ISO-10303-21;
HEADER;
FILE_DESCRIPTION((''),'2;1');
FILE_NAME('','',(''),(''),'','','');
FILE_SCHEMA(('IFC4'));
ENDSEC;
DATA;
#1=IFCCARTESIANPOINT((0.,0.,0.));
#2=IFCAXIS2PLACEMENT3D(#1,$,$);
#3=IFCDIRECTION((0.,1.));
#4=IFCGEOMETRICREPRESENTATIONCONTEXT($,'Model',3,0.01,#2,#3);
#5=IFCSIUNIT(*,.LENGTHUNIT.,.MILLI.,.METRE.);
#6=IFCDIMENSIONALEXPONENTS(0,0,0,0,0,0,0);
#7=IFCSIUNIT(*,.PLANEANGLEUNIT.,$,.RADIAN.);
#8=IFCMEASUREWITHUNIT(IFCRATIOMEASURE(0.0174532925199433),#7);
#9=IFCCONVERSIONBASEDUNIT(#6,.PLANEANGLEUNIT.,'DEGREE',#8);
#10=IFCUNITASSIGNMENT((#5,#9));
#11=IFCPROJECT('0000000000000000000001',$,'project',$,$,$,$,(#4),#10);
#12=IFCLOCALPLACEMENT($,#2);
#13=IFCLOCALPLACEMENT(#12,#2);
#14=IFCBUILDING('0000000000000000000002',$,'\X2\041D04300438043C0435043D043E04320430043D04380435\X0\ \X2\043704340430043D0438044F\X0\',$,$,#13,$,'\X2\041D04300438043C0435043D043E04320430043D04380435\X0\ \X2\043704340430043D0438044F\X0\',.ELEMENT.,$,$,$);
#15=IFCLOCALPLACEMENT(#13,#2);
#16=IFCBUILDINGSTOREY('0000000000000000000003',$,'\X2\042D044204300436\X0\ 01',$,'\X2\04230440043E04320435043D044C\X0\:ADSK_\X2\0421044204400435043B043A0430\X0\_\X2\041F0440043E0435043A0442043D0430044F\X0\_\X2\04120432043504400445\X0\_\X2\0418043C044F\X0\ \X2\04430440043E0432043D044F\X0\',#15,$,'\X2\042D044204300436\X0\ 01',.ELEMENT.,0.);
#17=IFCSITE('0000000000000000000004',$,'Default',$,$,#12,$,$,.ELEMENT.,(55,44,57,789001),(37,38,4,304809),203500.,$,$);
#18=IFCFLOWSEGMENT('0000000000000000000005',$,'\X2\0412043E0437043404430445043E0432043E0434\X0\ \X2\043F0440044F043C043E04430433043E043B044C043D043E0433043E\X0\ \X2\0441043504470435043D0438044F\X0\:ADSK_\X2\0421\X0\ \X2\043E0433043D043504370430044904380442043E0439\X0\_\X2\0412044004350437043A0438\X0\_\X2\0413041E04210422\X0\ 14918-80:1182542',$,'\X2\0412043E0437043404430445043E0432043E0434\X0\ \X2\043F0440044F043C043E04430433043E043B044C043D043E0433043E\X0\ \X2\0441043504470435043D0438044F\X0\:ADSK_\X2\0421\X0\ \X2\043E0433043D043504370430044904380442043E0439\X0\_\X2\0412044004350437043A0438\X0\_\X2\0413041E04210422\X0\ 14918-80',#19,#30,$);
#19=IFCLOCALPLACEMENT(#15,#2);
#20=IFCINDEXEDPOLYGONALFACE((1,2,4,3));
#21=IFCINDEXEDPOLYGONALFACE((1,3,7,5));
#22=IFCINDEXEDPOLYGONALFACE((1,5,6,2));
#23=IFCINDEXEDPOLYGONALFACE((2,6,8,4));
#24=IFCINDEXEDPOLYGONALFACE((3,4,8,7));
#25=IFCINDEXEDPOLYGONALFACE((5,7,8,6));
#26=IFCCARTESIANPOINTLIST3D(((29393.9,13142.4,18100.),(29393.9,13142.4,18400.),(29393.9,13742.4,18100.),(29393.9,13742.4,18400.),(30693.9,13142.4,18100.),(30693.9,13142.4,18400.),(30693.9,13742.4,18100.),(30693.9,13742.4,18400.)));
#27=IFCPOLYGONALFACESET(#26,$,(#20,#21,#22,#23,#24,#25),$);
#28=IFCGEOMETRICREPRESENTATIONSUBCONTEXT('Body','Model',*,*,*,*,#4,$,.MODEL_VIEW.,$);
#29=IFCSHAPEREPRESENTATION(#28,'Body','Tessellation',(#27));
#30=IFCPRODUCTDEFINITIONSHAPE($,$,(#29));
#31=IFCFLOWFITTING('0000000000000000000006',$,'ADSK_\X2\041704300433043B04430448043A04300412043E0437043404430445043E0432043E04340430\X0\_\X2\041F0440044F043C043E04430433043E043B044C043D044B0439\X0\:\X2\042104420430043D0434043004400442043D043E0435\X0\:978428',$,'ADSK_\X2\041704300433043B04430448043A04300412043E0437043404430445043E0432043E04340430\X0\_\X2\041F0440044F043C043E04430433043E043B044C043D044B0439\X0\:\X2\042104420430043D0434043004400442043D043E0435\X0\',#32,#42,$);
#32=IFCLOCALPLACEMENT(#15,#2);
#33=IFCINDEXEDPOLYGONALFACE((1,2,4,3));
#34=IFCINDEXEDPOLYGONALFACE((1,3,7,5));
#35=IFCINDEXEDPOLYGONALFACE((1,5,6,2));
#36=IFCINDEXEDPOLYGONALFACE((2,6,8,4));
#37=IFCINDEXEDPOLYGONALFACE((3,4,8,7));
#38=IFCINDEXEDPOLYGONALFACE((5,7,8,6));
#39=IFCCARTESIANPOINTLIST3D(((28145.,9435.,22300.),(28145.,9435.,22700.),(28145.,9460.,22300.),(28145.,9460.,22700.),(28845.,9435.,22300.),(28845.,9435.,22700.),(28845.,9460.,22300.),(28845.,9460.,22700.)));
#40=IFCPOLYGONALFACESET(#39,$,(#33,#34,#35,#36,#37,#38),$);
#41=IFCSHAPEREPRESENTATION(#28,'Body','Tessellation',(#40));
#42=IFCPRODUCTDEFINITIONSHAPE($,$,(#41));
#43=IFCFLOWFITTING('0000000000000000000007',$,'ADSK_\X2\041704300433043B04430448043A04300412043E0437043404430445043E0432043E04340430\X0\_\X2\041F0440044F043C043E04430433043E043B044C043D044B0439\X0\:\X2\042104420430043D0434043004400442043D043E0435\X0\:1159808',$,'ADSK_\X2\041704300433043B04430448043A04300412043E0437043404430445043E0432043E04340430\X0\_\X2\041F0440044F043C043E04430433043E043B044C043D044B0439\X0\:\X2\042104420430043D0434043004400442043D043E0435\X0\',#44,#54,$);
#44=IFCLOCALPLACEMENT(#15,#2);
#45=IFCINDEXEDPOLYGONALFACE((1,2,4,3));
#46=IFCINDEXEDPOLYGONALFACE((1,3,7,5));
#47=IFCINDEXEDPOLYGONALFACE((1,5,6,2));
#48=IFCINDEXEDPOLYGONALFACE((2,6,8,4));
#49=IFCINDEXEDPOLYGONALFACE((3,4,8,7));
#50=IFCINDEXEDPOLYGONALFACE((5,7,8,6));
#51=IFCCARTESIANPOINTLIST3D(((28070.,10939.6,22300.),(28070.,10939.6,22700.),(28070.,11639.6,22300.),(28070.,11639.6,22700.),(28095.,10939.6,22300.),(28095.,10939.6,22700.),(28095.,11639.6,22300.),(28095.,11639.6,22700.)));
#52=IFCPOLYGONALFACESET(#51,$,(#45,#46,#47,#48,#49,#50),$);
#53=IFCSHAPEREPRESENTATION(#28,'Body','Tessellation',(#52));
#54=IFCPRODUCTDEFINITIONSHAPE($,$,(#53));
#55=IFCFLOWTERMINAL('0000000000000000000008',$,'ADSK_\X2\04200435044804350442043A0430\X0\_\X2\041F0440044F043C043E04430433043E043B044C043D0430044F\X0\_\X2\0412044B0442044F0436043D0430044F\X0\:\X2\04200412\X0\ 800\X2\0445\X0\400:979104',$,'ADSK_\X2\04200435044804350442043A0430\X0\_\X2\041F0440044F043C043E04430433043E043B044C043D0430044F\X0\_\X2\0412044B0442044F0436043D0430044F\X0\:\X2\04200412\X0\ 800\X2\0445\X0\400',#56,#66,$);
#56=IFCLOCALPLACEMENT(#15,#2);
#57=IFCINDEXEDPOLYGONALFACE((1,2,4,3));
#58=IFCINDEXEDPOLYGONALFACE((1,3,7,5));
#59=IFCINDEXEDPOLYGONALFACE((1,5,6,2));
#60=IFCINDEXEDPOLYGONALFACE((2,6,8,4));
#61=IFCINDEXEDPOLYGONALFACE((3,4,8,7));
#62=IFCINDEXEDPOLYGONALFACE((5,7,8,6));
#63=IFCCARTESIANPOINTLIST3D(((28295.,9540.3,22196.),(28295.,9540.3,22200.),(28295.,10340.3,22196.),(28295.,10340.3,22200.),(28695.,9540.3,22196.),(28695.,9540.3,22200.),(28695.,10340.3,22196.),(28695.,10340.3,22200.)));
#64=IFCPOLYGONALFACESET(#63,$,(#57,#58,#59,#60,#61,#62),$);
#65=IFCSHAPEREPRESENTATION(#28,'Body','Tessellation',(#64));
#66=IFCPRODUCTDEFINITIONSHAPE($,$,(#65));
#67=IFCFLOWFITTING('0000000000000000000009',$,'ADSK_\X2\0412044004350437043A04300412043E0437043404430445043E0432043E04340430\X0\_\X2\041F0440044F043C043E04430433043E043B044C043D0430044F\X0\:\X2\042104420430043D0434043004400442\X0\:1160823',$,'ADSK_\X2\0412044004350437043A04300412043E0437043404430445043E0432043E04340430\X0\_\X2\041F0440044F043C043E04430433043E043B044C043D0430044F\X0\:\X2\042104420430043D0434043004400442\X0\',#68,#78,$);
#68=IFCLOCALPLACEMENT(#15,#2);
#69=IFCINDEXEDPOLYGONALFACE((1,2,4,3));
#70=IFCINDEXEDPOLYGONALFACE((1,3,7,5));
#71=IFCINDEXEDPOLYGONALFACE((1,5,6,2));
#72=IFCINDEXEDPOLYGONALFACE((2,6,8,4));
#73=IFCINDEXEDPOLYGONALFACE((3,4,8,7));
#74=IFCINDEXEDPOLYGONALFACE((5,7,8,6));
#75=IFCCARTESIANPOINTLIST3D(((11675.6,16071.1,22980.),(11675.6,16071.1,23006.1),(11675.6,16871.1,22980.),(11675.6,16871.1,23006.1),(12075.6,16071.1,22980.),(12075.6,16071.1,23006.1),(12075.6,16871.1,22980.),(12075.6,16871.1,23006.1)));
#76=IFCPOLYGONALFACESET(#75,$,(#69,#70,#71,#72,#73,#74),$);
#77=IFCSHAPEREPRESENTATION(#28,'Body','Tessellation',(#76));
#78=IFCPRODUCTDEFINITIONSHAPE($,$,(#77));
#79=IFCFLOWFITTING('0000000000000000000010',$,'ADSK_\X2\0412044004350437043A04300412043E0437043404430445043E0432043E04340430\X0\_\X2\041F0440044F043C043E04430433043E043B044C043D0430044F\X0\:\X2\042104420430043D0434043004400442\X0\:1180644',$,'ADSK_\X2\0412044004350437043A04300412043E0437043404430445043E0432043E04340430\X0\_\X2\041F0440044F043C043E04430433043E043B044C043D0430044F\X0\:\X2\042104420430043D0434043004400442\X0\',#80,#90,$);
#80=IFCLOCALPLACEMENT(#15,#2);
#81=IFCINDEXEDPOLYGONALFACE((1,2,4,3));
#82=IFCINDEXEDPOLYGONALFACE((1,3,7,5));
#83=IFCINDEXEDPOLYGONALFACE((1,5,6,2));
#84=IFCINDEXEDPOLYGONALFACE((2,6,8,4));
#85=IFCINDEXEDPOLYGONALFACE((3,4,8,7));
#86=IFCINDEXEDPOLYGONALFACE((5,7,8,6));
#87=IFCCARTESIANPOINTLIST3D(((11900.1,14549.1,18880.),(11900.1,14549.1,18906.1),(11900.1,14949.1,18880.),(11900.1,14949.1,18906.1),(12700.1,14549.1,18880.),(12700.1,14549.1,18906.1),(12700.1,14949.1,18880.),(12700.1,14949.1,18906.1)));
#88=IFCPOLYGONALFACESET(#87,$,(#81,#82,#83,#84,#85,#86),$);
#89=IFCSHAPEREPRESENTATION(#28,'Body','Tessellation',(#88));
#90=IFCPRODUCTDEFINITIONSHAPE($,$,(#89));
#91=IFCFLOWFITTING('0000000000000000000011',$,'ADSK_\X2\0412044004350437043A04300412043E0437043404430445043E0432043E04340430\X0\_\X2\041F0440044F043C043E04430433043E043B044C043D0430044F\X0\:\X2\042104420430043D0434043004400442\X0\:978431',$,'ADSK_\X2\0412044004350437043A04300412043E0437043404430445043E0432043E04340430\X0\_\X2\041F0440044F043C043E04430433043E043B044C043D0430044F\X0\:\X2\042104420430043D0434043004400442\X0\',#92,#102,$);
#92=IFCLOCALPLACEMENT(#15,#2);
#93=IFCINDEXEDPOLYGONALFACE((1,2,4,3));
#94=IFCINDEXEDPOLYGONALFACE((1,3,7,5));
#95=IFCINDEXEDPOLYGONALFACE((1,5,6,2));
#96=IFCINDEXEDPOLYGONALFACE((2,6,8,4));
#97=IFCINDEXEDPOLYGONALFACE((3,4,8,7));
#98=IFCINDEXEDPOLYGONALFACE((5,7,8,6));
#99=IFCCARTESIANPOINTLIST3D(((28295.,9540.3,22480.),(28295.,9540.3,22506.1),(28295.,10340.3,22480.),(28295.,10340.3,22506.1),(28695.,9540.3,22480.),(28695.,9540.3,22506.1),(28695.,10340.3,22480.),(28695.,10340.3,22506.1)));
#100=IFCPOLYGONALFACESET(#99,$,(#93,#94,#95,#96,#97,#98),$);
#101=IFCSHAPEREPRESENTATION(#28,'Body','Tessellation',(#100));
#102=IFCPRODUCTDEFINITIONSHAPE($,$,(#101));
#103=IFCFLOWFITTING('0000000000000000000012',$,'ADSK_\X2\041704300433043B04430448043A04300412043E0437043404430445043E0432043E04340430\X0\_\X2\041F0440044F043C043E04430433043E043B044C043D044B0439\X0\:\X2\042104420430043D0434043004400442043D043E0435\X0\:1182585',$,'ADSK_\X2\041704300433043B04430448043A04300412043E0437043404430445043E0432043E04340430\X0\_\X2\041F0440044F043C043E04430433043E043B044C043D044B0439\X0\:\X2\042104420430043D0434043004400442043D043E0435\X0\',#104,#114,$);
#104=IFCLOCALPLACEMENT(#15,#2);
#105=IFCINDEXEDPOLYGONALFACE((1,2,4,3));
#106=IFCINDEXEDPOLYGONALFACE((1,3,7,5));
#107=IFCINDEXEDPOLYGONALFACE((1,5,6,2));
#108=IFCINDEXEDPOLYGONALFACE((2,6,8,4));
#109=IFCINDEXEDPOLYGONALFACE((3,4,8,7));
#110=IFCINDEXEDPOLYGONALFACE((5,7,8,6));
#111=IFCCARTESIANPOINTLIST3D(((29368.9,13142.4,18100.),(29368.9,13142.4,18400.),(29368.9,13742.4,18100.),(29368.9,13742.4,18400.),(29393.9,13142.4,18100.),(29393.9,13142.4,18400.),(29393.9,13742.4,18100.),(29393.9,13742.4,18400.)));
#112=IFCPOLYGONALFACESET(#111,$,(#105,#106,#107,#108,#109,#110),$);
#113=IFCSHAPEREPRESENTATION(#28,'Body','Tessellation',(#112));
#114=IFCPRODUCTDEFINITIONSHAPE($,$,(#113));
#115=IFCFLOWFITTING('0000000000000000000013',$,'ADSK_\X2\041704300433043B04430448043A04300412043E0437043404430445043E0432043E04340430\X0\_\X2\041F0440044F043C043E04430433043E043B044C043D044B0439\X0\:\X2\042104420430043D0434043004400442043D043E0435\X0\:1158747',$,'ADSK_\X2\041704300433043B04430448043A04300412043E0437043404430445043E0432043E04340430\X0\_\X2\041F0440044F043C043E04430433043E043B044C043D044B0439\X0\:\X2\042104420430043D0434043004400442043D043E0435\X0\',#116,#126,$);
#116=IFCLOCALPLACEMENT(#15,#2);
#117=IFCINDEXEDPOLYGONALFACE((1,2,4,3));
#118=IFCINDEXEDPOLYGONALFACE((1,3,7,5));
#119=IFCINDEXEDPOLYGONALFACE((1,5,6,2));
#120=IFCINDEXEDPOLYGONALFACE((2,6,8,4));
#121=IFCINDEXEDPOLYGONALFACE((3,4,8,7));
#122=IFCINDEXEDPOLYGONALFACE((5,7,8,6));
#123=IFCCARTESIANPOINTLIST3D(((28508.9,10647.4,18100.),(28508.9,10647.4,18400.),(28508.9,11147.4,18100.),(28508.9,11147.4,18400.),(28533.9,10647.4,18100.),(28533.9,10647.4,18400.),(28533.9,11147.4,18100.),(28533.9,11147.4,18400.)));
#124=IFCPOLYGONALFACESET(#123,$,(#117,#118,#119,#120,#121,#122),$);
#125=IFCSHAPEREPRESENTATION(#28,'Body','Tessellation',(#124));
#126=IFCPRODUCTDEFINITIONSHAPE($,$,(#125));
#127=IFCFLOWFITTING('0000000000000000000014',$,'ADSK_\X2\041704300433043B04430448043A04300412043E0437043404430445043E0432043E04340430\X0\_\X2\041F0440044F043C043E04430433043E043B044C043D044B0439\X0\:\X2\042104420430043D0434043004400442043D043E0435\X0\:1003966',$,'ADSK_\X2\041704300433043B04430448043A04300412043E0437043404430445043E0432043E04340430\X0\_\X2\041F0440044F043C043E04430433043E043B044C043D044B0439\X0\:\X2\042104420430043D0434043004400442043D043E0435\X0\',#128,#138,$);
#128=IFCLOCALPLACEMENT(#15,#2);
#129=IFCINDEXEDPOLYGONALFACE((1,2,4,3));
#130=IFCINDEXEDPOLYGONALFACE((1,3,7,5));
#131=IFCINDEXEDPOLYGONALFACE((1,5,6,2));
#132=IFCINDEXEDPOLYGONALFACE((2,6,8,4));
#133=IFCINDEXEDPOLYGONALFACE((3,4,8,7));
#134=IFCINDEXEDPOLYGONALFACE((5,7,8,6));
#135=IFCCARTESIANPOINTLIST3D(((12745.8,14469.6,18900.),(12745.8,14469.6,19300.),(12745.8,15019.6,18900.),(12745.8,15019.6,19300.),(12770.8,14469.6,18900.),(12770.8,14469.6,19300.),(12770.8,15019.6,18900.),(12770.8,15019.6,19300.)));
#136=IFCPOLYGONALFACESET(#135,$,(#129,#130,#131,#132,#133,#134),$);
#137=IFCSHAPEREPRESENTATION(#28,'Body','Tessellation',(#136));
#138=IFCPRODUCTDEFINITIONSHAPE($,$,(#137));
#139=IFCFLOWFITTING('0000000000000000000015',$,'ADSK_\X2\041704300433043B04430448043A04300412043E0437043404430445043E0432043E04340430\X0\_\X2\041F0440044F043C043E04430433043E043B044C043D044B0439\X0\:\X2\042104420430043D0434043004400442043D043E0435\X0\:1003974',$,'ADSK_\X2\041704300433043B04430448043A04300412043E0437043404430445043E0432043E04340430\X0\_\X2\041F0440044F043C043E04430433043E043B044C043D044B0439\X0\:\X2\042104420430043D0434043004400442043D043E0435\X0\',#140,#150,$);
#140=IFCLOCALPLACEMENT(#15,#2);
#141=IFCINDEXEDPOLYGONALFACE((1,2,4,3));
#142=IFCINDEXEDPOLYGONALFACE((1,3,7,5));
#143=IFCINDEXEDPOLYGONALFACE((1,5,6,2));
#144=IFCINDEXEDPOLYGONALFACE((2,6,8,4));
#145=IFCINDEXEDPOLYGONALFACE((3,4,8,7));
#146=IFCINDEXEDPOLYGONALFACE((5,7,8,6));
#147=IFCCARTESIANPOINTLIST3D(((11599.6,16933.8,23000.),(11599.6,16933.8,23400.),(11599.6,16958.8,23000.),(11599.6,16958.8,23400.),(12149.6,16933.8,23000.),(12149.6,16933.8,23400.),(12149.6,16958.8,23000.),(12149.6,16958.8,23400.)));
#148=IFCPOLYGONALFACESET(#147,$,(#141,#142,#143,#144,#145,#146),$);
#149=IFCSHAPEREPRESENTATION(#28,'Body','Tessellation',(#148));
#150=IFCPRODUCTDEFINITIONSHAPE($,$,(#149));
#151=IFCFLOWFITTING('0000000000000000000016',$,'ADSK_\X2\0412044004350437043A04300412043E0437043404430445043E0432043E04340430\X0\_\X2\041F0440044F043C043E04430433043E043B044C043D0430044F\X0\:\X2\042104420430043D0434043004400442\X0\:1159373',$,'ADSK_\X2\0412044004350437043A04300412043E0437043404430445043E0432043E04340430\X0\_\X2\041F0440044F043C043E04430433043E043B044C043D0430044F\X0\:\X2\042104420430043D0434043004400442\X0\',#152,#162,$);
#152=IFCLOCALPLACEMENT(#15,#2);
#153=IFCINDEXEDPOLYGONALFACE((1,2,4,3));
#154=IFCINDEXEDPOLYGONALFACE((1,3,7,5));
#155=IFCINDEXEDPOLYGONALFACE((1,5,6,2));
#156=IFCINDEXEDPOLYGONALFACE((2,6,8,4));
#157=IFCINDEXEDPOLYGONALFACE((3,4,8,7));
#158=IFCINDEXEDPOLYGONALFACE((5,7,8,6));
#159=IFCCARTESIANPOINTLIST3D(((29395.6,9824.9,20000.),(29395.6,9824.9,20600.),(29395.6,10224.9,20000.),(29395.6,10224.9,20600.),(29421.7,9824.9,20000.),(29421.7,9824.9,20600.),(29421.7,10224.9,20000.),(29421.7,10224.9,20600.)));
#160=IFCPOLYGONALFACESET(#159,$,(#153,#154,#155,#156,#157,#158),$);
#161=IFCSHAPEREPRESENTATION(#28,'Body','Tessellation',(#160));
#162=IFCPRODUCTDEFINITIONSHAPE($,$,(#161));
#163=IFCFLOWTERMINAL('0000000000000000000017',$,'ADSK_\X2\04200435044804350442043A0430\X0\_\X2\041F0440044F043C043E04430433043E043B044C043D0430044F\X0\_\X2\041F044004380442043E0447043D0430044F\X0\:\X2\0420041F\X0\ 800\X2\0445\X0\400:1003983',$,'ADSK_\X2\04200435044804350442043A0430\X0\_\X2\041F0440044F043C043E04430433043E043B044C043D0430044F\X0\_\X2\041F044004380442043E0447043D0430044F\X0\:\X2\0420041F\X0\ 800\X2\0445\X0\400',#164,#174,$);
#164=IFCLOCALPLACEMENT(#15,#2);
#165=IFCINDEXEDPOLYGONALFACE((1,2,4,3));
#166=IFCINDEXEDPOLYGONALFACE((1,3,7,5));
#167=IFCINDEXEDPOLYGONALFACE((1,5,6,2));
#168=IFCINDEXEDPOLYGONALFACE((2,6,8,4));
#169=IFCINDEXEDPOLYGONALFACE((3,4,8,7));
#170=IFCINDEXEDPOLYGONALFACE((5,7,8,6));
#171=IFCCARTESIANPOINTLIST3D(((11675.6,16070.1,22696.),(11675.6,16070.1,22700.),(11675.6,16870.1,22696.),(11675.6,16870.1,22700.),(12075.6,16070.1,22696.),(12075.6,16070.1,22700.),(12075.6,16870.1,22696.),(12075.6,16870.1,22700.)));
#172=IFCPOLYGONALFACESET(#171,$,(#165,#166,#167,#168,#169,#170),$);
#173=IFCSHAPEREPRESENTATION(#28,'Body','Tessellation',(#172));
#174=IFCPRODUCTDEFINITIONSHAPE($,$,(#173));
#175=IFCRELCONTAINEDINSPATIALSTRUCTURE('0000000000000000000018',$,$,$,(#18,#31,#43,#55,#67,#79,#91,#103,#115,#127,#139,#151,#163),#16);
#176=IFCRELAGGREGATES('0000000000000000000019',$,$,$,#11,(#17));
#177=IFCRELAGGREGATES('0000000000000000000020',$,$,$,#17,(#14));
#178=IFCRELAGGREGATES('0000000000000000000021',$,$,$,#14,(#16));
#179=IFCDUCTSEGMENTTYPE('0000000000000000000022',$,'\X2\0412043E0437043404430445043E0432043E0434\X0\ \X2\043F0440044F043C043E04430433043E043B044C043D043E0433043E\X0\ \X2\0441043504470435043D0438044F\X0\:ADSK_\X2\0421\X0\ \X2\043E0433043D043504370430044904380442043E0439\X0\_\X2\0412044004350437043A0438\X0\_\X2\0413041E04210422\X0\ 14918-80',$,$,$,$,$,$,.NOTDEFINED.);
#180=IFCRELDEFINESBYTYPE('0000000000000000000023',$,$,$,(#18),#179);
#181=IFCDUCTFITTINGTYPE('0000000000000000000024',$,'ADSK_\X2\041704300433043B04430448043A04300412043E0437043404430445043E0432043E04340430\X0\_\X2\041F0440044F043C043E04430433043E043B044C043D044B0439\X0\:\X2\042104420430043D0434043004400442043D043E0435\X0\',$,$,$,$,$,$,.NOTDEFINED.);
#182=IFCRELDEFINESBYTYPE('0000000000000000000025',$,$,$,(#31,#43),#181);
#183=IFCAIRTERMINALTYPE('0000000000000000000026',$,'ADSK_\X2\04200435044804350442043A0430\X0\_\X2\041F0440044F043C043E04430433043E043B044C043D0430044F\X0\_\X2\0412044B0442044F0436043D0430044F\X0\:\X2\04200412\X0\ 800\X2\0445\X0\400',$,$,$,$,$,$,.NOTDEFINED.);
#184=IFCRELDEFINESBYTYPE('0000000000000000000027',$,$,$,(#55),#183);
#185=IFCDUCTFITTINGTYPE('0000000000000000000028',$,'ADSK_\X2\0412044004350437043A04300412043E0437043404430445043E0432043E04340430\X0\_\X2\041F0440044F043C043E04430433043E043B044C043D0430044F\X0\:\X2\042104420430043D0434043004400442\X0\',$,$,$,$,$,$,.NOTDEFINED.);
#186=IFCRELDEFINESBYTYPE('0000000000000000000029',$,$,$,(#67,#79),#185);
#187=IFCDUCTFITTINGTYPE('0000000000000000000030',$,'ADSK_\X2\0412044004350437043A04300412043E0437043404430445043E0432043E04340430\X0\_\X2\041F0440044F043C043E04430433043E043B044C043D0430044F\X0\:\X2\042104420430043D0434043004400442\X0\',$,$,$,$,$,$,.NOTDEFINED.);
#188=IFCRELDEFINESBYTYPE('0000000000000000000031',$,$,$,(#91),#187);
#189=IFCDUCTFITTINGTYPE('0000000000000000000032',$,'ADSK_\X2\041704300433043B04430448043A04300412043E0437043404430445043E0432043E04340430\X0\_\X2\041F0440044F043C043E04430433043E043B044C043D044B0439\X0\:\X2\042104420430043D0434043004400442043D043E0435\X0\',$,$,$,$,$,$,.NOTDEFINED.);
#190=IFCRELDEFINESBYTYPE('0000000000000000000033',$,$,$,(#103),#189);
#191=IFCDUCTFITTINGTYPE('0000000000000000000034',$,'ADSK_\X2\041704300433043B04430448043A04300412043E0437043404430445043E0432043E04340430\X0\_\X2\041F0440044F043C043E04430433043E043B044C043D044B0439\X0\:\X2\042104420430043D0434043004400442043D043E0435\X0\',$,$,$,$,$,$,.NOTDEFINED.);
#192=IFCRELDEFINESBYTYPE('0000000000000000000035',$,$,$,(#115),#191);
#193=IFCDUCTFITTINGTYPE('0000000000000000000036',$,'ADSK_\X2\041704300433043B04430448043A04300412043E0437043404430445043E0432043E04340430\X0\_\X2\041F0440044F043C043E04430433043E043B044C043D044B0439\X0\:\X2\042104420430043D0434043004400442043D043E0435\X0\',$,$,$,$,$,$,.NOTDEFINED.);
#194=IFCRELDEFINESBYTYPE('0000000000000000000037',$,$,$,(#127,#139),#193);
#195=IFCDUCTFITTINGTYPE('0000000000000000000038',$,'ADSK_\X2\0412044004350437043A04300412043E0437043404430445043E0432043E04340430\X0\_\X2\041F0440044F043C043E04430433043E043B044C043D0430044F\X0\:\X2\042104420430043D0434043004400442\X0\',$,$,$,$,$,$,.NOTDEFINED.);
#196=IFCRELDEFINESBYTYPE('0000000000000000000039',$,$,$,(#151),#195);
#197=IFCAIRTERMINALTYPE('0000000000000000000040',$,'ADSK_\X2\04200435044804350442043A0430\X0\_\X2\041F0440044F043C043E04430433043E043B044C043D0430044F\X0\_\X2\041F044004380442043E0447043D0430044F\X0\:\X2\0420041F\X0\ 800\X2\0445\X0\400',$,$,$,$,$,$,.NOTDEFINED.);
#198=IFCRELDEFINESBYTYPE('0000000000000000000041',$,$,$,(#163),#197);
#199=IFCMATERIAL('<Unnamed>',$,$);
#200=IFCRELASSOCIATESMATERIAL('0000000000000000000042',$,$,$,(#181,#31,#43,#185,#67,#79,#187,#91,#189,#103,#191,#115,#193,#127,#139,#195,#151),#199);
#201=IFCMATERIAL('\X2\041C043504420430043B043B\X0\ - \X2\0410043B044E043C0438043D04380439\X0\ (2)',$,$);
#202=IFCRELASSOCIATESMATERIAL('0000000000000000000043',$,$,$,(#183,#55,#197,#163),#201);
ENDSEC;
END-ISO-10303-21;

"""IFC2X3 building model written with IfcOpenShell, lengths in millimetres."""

from ifc_helpers import new_model, entity, si_unit, converted_unit, direction, frame, frame_2d, origin, origin_2d_with_axis, place, context, subcontext, project, spatial, rectangle, extrude, source, transform, mapped, material, type_object, type_shapes, element, save


model = new_model("IFC2X3")

# Units and contexts
model_context = context("Model", 3, precision=0.01, world=origin(), true_north=direction((0.0, 1.0)))
body_context = subcontext(model_context, "Body", "Model", "MODEL_VIEW")
ifc_project = project(units=[si_unit("LENGTHUNIT", "METRE", prefix="MILLI"), converted_unit("PLANEANGLEUNIT", "DEGREE", entity("IfcRatioMeasure", 0.0174532925199433), si_unit("PLANEANGLEUNIT", "RADIAN"), dimensions=[0, 0, 0, 0, 0, 0, 0])], contexts=[model_context])

# Site, building, storey
site_placement = place(None, frame((0.0, 0.0, 0.0)))
site = spatial("IfcSite", under=ifc_project, at=site_placement, Name="Default", CompositionType="ELEMENT", RefLatitude=(55, 44, 57, 789001), RefLongitude=(37, 38, 4, 304809), RefElevation=203500.0)
building_placement = place(site_placement, origin())
building = spatial("IfcBuilding", under=site, at=building_placement, Name="Наименование здания", LongName="Наименование здания", CompositionType="ELEMENT")
storey_placement = place(building_placement, origin())
storey = spatial("IfcBuildingStorey", under=building, at=storey_placement, Name="Этаж 01", ObjectType="Уровень:ADSK_Стрелка_Проектная_Вверх_Имя уровня", LongName="Этаж 01", CompositionType="ELEMENT", Elevation=0.0)

# Flow segment
duct_segment_type = type_object("IfcDuctSegmentType", Name="Воздуховод прямоугольного сечения:ADSK_С огнезащитой_Врезки_ГОСТ 14918-80", PredefinedType="NOTDEFINED")
flow_segment_1_placement = place(storey_placement, frame((29393.9, 13142.4, 18100.0)))
element("IfcFlowSegment", 1, at=flow_segment_1_placement, inside=storey, type_object=duct_segment_type, Name="Воздуховод прямоугольного сечения:ADSK_С огнезащитой_Врезки_ГОСТ 14918-80:1182542", ObjectType="Воздуховод прямоугольного сечения:ADSK_С огнезащитой_Врезки_ГОСТ 14918-80", context=body_context, shape_type="SweptSolid", body=[
    extrude(rectangle(XDim=1300.0, YDim=600.0, at=frame_2d((0.0, 0.0), x_axis=(1.0, 0.0))), frame((650.0, 300.0, 0.0), z_axis=(0.0, 0.0, 1.0), x_axis=(-1.0, 0.0, 0.0)), (0.0, 0.0, 1.0), 300.0),
])

# Flow fittings
ifc_material_1 = material(Name="<Unnamed>")
duct_fitting_type_1 = type_object("IfcDuctFittingType", Name="ADSK_ЗаглушкаВоздуховода_Прямоугольный:Стандартное", PredefinedType="NOTDEFINED", material=ifc_material_1)
shared_shape_1 = source(origin(), body_context, "Body", "SweptSolid", [
    extrude(rectangle(XDim=25.0, YDim=700.0, at=frame_2d((0.0, 0.0), x_axis=(1.0, 0.0))), frame((12.5, 0.0, -200.0)), (0.0, 0.0, 1.0), 400.0),
])
type_shapes(duct_fitting_type_1, [shared_shape_1])
for number, where, z_axis, x_axis, name in (
    (2, (28495.0, 9460.0, 22500.0), (0.0, 0.0, 1.0), (0.0, -1.0, 0.0), "ADSK_ЗаглушкаВоздуховода_Прямоугольный:Стандартное:978428"),
    (3, (28095.0, 11289.6, 22500.0), (0.0, 0.0, 1.0), (-1.0, 0.0, 0.0), "ADSK_ЗаглушкаВоздуховода_Прямоугольный:Стандартное:1159808"),
):
    element("IfcFlowFitting", number, at=place(storey_placement, frame(where, z_axis=z_axis, x_axis=x_axis)), inside=storey, type_object=duct_fitting_type_1, material=ifc_material_1, Name=name, ObjectType="ADSK_ЗаглушкаВоздуховода_Прямоугольный:Стандартное", context=body_context, shape_type="MappedRepresentation", body=[
        mapped(shared_shape_1, transform((0.0, 0.0, 0.0), scale=1.0)),
    ])

# Flow terminal
ifc_material_2 = material(Name="Металл - Алюминий (2)")
air_terminal_type_1 = type_object("IfcAirTerminalType", Name="ADSK_Решетка_Прямоугольная_Вытяжная:РВ 800х400", PredefinedType="NOTDEFINED", material=ifc_material_2)
shared_shape_2 = source(origin(), body_context, "Body", "SweptSolid", [
    extrude(rectangle(XDim=4.0, YDim=800.0, at=origin_2d_with_axis()), frame((0.0, -2.0, -200.0), z_axis=(0.0, 0.0, 1.0), x_axis=(0.0, 1.0, 0.0)), (0.0, 0.0, 1.0), 400.0),
])
type_shapes(air_terminal_type_1, [shared_shape_2])
flow_terminal_1_placement = place(storey_placement, frame((28495.0, 9940.3, 22200.0), z_axis=(-1.0, 0.0, 0.0), x_axis=(0.0, -1.0, 0.0)))
element("IfcFlowTerminal", 4, at=flow_terminal_1_placement, inside=storey, type_object=air_terminal_type_1, material=ifc_material_2, Name="ADSK_Решетка_Прямоугольная_Вытяжная:РВ 800х400:979104", ObjectType="ADSK_Решетка_Прямоугольная_Вытяжная:РВ 800х400", context=body_context, shape_type="MappedRepresentation", body=[
    mapped(shared_shape_2, transform((0.0, 0.0, 0.0), scale=1.0)),
])

# Flow fittings
duct_fitting_type_2 = type_object("IfcDuctFittingType", Name="ADSK_ВрезкаВоздуховода_Прямоугольная:Стандарт", PredefinedType="NOTDEFINED", material=ifc_material_1)
shared_shape_3 = source(origin(), body_context, "Body", "SweptSolid", [
    extrude(rectangle(XDim=26.1, YDim=800.0, at=frame_2d((0.0, 0.0), x_axis=(1.0, 0.0))), frame((7.0, 0.0, -200.0)), (0.0, 0.0, 1.0), 400.0),
])
type_shapes(duct_fitting_type_2, [shared_shape_3])
for number, where, z_axis, x_axis, name in (
    (5, (11875.6, 16471.1, 23000.0), (1.0, 0.0, 0.0), (0.0, 0.0, -1.0), "ADSK_ВрезкаВоздуховода_Прямоугольная:Стандарт:1160823"),
    (6, (12300.1, 14749.1, 18900.0), (0.0, 1.0, 0.0), (0.0, 0.0, -1.0), "ADSK_ВрезкаВоздуховода_Прямоугольная:Стандарт:1180644"),
):
    element("IfcFlowFitting", number, at=place(storey_placement, frame(where, z_axis=z_axis, x_axis=x_axis)), inside=storey, type_object=duct_fitting_type_2, material=ifc_material_1, Name=name, ObjectType="ADSK_ВрезкаВоздуховода_Прямоугольная:Стандарт", context=body_context, shape_type="MappedRepresentation", body=[
        mapped(shared_shape_3, transform((0.0, 0.0, 0.0), scale=1.0)),
    ])
duct_fitting_type_3 = type_object("IfcDuctFittingType", Name="ADSK_ВрезкаВоздуховода_Прямоугольная:Стандарт", PredefinedType="NOTDEFINED", material=ifc_material_1)
shared_shape_4 = source(origin(), body_context, "Body", "SweptSolid", [
    extrude(rectangle(XDim=800.0, YDim=26.1, at=frame_2d((0.0, 0.0), x_axis=(1.0, 0.0))), frame((7.0, 0.0, -200.0), z_axis=(0.0, 0.0, 1.0), x_axis=(0.0, -1.0, 0.0)), (0.0, 0.0, 1.0), 400.0),
])
type_shapes(duct_fitting_type_3, [shared_shape_4])
flow_fitting_1_placement = place(storey_placement, frame((28495.0, 9940.3, 22500.0), z_axis=(-1.0, 0.0, 0.0), x_axis=(0.0, 0.0, -1.0)))
element("IfcFlowFitting", 7, at=flow_fitting_1_placement, inside=storey, type_object=duct_fitting_type_3, material=ifc_material_1, Name="ADSK_ВрезкаВоздуховода_Прямоугольная:Стандарт:978431", ObjectType="ADSK_ВрезкаВоздуховода_Прямоугольная:Стандарт", context=body_context, shape_type="MappedRepresentation", body=[
    mapped(shared_shape_4, transform((0.0, 0.0, 0.0), scale=1.0)),
])
duct_fitting_type_4 = type_object("IfcDuctFittingType", Name="ADSK_ЗаглушкаВоздуховода_Прямоугольный:Стандартное", PredefinedType="NOTDEFINED", material=ifc_material_1)
shared_shape_5 = source(origin(), body_context, "Body", "SweptSolid", [
    extrude(rectangle(XDim=25.0, YDim=600.0, at=frame_2d((0.0, 0.0), x_axis=(1.0, 0.0))), frame((12.5, 0.0, -150.0)), (0.0, 0.0, 1.0), 300.0),
])
type_shapes(duct_fitting_type_4, [shared_shape_5])
flow_fitting_2_placement = place(storey_placement, frame((29393.9, 13442.4, 18250.0), z_axis=(0.0, 0.0, 1.0), x_axis=(-1.0, 0.0, 0.0)))
element("IfcFlowFitting", 8, at=flow_fitting_2_placement, inside=storey, type_object=duct_fitting_type_4, material=ifc_material_1, Name="ADSK_ЗаглушкаВоздуховода_Прямоугольный:Стандартное:1182585", ObjectType="ADSK_ЗаглушкаВоздуховода_Прямоугольный:Стандартное", context=body_context, shape_type="MappedRepresentation", body=[
    mapped(shared_shape_5, transform((0.0, 0.0, 0.0), scale=1.0)),
])
duct_fitting_type_5 = type_object("IfcDuctFittingType", Name="ADSK_ЗаглушкаВоздуховода_Прямоугольный:Стандартное", PredefinedType="NOTDEFINED", material=ifc_material_1)
shared_shape_6 = source(origin(), body_context, "Body", "SweptSolid", [
    extrude(rectangle(XDim=25.0, YDim=500.0, at=frame_2d((0.0, 0.0), x_axis=(1.0, 0.0))), frame((12.5, 0.0, -150.0)), (0.0, 0.0, 1.0), 300.0),
])
type_shapes(duct_fitting_type_5, [shared_shape_6])
flow_fitting_3_placement = place(storey_placement, frame((28533.9, 10897.4, 18250.0), z_axis=(0.0, 0.0, 1.0), x_axis=(-1.0, 0.0, 0.0)))
element("IfcFlowFitting", 9, at=flow_fitting_3_placement, inside=storey, type_object=duct_fitting_type_5, material=ifc_material_1, Name="ADSK_ЗаглушкаВоздуховода_Прямоугольный:Стандартное:1158747", ObjectType="ADSK_ЗаглушкаВоздуховода_Прямоугольный:Стандартное", context=body_context, shape_type="MappedRepresentation", body=[
    mapped(shared_shape_6, transform((0.0, 0.0, 0.0), scale=1.0)),
])
duct_fitting_type_6 = type_object("IfcDuctFittingType", Name="ADSK_ЗаглушкаВоздуховода_Прямоугольный:Стандартное", PredefinedType="NOTDEFINED", material=ifc_material_1)
shared_shape_7 = source(origin(), body_context, "Body", "SweptSolid", [
    extrude(rectangle(XDim=25.0, YDim=550.0, at=frame_2d((0.0, 0.0), x_axis=(1.0, 0.0))), frame((12.5, 0.0, -200.0)), (0.0, 0.0, 1.0), 400.0),
])
type_shapes(duct_fitting_type_6, [shared_shape_7])
flow_fitting_4_placement = place(storey_placement, frame((12745.8, 14744.6, 19100.0)))
element("IfcFlowFitting", 10, at=flow_fitting_4_placement, inside=storey, type_object=duct_fitting_type_6, material=ifc_material_1, Name="ADSK_ЗаглушкаВоздуховода_Прямоугольный:Стандартное:1003966", ObjectType="ADSK_ЗаглушкаВоздуховода_Прямоугольный:Стандартное", context=body_context, shape_type="MappedRepresentation", body=[
    mapped(shared_shape_7, transform((0.0, 0.0, 0.0), scale=1.0)),
])
flow_fitting_5_placement = place(storey_placement, frame((11874.6, 16933.8, 23200.0), z_axis=(0.0, 0.0, 1.0), x_axis=(0.0, 1.0, 0.0)))
element("IfcFlowFitting", 11, at=flow_fitting_5_placement, inside=storey, type_object=duct_fitting_type_6, material=ifc_material_1, Name="ADSK_ЗаглушкаВоздуховода_Прямоугольный:Стандартное:1003974", ObjectType="ADSK_ЗаглушкаВоздуховода_Прямоугольный:Стандартное", context=body_context, shape_type="MappedRepresentation", body=[
    mapped(shared_shape_7, transform((0.0, 0.0, 0.0), scale=1.0)),
])
duct_fitting_type_7 = type_object("IfcDuctFittingType", Name="ADSK_ВрезкаВоздуховода_Прямоугольная:Стандарт", PredefinedType="NOTDEFINED", material=ifc_material_1)
shared_shape_8 = source(origin(), body_context, "Body", "SweptSolid", [
    extrude(rectangle(XDim=600.0, YDim=26.1, at=origin_2d_with_axis()), frame((7.0, 0.0, -200.0), z_axis=(0.0, 0.0, 1.0), x_axis=(0.0, -1.0, 0.0)), (0.0, 0.0, 1.0), 400.0),
])
type_shapes(duct_fitting_type_7, [shared_shape_8])
flow_fitting_6_placement = place(storey_placement, frame((29415.6, 10024.9, 20300.0), z_axis=(0.0, 1.0, 0.0), x_axis=(-1.0, 0.0, 0.0)))
element("IfcFlowFitting", 12, at=flow_fitting_6_placement, inside=storey, type_object=duct_fitting_type_7, material=ifc_material_1, Name="ADSK_ВрезкаВоздуховода_Прямоугольная:Стандарт:1159373", ObjectType="ADSK_ВрезкаВоздуховода_Прямоугольная:Стандарт", context=body_context, shape_type="MappedRepresentation", body=[
    mapped(shared_shape_8, transform((0.0, 0.0, 0.0), scale=1.0)),
])

# Flow terminal
air_terminal_type_2 = type_object("IfcAirTerminalType", Name="ADSK_Решетка_Прямоугольная_Приточная:РП 800х400", PredefinedType="NOTDEFINED", material=ifc_material_2)
shared_shape_9 = source(origin(), body_context, "Body", "SweptSolid", [
    extrude(rectangle(XDim=4.0, YDim=800.0, at=origin_2d_with_axis()), frame((0.0, -2.0, -200.0), z_axis=(0.0, 0.0, 1.0), x_axis=(0.0, 1.0, 0.0)), (0.0, 0.0, 1.0), 400.0),
])
type_shapes(air_terminal_type_2, [shared_shape_9])
flow_terminal_2_placement = place(storey_placement, frame((11875.6, 16470.1, 22700.0), z_axis=(-1.0, 0.0, 0.0), x_axis=(0.0, -1.0, 0.0)))
element("IfcFlowTerminal", 13, at=flow_terminal_2_placement, inside=storey, type_object=air_terminal_type_2, material=ifc_material_2, Name="ADSK_Решетка_Прямоугольная_Приточная:РП 800х400:1003983", ObjectType="ADSK_Решетка_Прямоугольная_Приточная:РП 800х400", context=body_context, shape_type="MappedRepresentation", body=[
    mapped(shared_shape_9, transform((0.0, 0.0, 0.0), scale=1.0)),
])

save(model, "model.ifc")
